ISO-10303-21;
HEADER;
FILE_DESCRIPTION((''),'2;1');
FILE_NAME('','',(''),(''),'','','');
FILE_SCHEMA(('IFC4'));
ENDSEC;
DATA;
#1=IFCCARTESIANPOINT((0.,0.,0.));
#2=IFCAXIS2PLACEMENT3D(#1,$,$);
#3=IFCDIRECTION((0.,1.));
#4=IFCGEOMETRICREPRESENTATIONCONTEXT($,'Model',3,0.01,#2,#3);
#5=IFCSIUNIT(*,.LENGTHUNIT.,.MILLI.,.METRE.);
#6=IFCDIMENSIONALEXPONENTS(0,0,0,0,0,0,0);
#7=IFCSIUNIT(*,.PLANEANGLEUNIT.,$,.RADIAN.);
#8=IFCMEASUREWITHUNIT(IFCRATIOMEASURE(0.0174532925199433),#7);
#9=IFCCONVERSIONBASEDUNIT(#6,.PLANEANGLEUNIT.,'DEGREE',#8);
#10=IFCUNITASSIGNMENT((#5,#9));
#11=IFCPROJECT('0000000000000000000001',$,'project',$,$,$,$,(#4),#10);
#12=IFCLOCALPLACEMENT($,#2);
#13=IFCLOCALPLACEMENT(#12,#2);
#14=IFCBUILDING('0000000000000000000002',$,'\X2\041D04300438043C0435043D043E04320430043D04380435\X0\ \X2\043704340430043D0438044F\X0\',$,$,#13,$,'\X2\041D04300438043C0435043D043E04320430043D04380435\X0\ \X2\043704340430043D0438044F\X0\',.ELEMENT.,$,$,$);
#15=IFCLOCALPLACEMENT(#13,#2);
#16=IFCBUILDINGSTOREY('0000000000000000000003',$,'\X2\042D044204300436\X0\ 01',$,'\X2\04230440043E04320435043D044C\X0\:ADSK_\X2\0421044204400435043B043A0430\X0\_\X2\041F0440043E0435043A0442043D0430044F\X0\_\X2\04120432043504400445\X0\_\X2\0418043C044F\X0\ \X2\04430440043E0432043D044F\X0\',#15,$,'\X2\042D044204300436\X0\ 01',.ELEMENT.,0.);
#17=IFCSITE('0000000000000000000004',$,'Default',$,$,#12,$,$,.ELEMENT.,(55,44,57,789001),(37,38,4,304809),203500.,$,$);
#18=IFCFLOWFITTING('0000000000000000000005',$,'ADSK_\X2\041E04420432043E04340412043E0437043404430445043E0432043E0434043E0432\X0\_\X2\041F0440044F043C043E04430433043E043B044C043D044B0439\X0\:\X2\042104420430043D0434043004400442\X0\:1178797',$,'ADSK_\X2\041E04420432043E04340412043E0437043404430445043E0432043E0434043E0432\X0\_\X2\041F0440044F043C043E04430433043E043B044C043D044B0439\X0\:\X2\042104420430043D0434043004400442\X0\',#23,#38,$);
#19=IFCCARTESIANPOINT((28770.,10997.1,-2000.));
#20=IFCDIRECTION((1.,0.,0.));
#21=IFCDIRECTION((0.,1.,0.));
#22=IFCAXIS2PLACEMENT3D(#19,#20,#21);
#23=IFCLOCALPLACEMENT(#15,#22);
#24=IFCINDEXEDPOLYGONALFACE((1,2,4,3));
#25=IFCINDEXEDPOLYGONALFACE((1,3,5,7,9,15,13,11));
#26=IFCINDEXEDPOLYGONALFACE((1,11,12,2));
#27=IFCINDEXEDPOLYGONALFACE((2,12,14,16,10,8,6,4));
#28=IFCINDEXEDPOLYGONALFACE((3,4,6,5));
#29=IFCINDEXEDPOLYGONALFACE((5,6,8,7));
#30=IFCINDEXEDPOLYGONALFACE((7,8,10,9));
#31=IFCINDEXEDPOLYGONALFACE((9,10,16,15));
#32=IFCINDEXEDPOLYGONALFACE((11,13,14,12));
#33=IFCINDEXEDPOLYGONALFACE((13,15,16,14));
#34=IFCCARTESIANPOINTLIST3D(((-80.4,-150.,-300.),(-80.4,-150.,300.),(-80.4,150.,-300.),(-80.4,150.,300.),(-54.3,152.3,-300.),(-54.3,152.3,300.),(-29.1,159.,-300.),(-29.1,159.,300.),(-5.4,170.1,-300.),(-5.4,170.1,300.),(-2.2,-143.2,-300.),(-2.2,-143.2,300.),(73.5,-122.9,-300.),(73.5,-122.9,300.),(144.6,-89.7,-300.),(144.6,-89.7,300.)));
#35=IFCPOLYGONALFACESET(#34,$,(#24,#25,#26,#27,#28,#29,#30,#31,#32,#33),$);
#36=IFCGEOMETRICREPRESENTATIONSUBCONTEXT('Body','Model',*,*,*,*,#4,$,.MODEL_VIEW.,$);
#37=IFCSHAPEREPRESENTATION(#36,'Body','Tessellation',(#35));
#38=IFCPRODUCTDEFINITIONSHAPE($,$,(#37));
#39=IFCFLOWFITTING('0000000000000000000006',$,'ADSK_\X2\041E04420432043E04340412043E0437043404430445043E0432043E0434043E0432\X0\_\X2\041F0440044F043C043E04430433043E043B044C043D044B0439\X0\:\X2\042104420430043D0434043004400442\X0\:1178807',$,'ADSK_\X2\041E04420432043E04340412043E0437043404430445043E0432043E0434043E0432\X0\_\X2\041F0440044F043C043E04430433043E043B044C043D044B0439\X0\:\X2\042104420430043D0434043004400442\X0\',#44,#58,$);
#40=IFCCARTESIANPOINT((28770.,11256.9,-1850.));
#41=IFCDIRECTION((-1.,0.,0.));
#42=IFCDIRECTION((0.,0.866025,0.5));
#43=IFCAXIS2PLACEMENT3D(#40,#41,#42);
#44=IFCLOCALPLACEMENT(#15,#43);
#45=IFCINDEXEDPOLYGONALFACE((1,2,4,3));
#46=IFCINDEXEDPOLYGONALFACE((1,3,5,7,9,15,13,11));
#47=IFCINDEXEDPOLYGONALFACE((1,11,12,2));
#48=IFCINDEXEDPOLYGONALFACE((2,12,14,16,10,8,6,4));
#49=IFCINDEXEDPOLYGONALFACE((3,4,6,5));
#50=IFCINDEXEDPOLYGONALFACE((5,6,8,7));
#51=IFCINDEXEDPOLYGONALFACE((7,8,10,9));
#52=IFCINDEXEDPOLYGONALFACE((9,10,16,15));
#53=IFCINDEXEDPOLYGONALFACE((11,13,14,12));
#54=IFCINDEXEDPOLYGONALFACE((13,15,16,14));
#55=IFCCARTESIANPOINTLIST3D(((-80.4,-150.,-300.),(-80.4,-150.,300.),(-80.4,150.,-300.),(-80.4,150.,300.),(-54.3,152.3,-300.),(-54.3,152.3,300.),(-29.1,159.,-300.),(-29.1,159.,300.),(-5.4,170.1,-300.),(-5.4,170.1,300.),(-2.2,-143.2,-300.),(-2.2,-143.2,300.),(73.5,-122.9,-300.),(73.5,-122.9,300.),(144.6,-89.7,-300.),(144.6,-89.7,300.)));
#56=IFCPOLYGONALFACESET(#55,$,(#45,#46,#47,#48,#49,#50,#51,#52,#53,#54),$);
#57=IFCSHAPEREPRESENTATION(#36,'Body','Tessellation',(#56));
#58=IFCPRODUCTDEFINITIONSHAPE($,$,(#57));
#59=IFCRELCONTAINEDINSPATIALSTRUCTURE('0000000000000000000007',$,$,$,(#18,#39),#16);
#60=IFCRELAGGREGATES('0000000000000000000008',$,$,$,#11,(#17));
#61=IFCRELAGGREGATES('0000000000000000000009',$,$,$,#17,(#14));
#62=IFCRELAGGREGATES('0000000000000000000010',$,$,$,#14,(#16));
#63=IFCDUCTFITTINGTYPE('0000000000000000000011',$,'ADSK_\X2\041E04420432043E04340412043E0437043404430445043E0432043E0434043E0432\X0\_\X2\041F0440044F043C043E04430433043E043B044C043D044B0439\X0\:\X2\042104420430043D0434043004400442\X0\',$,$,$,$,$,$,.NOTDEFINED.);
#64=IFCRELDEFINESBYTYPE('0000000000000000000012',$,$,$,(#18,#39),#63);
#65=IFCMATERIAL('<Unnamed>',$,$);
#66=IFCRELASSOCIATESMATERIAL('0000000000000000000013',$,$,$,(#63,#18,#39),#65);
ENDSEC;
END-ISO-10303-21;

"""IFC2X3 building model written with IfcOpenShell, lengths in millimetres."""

from ifc_helpers import new_model, entity, si_unit, converted_unit, direction, frame, frame_2d, origin, place, context, subcontext, project, spatial, polyline, circle_curve, parameter, trimmed, segment, composite_curve, outline, extrude, source, transform, mapped, material, type_object, type_shapes, element, save


model = new_model("IFC2X3")

# Units and contexts
model_context = context("Model", 3, precision=0.01, world=origin(), true_north=direction((0.0, 1.0)))
body_context = subcontext(model_context, "Body", "Model", "MODEL_VIEW")
ifc_project = project(units=[si_unit("LENGTHUNIT", "METRE", prefix="MILLI"), converted_unit("PLANEANGLEUNIT", "DEGREE", entity("IfcRatioMeasure", 0.0174532925199433), si_unit("PLANEANGLEUNIT", "RADIAN"), dimensions=[0, 0, 0, 0, 0, 0, 0])], contexts=[model_context])

# Site, building, storey
site_placement = place(None, frame((0.0, 0.0, 0.0)))
site = spatial("IfcSite", under=ifc_project, at=site_placement, Name="Default", CompositionType="ELEMENT", RefLatitude=(55, 44, 57, 789001), RefLongitude=(37, 38, 4, 304809), RefElevation=203500.0)
building_placement = place(site_placement, origin())
building = spatial("IfcBuilding", under=site, at=building_placement, Name="Наименование здания", LongName="Наименование здания", CompositionType="ELEMENT")
storey_placement = place(building_placement, origin())
storey = spatial("IfcBuildingStorey", under=building, at=storey_placement, Name="Этаж 01", ObjectType="Уровень:ADSK_Стрелка_Проектная_Вверх_Имя уровня", LongName="Этаж 01", CompositionType="ELEMENT", Elevation=0.0)

# Shared definitions
ifc_material_1 = material(Name="<Unnamed>")

# Flow fittings
duct_fitting_type_1 = type_object("IfcDuctFittingType", Name="ADSK_ОтводВоздуховодов_Прямоугольный:Стандарт", PredefinedType="NOTDEFINED", material=ifc_material_1)
shared_shape_1 = source(origin(), body_context, "Body", "SweptSolid", [
    extrude(outline(composite_curve([segment(polyline([(-170.1, -75.0), (129.9, -75.0)]), True, "CONTINUOUS"), segment(trimmed(circle_curve(frame_2d((279.9, -75.0), x_axis=(-0.866025, 0.5)), 150.0), [parameter(0.0)], [parameter(29.999999)], True, "PARAMETER"), False, "CONTINUOUS"), segment(polyline([(150.0, 0.0), (-109.8, 150.0)]), True, "CONTINUOUS"), segment(trimmed(circle_curve(frame_2d((279.9, -75.0), x_axis=(-0.866025, 0.5)), 450.0), [parameter(0.0)], [parameter(29.999999)], True, "PARAMETER"), True, "CONTINUOUS")], self_intersect=False)), frame((-5.4, 20.1, -300.0), z_axis=(0.0, 0.0, 1.0), x_axis=(-0.5, 0.866025, 0.0)), (0.0, 0.0, 1.0), 600.0),
])
type_shapes(duct_fitting_type_1, [shared_shape_1])
for number, where, z_axis, x_axis, name in (
    (1, (28770.0, 10997.1, -2000.0), (1.0, 0.0, 0.0), (0.0, 1.0, 0.0), "ADSK_ОтводВоздуховодов_Прямоугольный:Стандарт:1178797"),
    (2, (28770.0, 11256.9, -1850.0), (-1.0, 0.0, 0.0), (0.0, 0.866025, 0.5), "ADSK_ОтводВоздуховодов_Прямоугольный:Стандарт:1178807"),
):
    element("IfcFlowFitting", number, at=place(storey_placement, frame(where, z_axis=z_axis, x_axis=x_axis)), inside=storey, type_object=duct_fitting_type_1, material=ifc_material_1, Name=name, ObjectType="ADSK_ОтводВоздуховодов_Прямоугольный:Стандарт", context=body_context, shape_type="MappedRepresentation", body=[
        mapped(shared_shape_1, transform((0.0, 0.0, 0.0), scale=1.0)),
    ])

save(model, "model.ifc")
